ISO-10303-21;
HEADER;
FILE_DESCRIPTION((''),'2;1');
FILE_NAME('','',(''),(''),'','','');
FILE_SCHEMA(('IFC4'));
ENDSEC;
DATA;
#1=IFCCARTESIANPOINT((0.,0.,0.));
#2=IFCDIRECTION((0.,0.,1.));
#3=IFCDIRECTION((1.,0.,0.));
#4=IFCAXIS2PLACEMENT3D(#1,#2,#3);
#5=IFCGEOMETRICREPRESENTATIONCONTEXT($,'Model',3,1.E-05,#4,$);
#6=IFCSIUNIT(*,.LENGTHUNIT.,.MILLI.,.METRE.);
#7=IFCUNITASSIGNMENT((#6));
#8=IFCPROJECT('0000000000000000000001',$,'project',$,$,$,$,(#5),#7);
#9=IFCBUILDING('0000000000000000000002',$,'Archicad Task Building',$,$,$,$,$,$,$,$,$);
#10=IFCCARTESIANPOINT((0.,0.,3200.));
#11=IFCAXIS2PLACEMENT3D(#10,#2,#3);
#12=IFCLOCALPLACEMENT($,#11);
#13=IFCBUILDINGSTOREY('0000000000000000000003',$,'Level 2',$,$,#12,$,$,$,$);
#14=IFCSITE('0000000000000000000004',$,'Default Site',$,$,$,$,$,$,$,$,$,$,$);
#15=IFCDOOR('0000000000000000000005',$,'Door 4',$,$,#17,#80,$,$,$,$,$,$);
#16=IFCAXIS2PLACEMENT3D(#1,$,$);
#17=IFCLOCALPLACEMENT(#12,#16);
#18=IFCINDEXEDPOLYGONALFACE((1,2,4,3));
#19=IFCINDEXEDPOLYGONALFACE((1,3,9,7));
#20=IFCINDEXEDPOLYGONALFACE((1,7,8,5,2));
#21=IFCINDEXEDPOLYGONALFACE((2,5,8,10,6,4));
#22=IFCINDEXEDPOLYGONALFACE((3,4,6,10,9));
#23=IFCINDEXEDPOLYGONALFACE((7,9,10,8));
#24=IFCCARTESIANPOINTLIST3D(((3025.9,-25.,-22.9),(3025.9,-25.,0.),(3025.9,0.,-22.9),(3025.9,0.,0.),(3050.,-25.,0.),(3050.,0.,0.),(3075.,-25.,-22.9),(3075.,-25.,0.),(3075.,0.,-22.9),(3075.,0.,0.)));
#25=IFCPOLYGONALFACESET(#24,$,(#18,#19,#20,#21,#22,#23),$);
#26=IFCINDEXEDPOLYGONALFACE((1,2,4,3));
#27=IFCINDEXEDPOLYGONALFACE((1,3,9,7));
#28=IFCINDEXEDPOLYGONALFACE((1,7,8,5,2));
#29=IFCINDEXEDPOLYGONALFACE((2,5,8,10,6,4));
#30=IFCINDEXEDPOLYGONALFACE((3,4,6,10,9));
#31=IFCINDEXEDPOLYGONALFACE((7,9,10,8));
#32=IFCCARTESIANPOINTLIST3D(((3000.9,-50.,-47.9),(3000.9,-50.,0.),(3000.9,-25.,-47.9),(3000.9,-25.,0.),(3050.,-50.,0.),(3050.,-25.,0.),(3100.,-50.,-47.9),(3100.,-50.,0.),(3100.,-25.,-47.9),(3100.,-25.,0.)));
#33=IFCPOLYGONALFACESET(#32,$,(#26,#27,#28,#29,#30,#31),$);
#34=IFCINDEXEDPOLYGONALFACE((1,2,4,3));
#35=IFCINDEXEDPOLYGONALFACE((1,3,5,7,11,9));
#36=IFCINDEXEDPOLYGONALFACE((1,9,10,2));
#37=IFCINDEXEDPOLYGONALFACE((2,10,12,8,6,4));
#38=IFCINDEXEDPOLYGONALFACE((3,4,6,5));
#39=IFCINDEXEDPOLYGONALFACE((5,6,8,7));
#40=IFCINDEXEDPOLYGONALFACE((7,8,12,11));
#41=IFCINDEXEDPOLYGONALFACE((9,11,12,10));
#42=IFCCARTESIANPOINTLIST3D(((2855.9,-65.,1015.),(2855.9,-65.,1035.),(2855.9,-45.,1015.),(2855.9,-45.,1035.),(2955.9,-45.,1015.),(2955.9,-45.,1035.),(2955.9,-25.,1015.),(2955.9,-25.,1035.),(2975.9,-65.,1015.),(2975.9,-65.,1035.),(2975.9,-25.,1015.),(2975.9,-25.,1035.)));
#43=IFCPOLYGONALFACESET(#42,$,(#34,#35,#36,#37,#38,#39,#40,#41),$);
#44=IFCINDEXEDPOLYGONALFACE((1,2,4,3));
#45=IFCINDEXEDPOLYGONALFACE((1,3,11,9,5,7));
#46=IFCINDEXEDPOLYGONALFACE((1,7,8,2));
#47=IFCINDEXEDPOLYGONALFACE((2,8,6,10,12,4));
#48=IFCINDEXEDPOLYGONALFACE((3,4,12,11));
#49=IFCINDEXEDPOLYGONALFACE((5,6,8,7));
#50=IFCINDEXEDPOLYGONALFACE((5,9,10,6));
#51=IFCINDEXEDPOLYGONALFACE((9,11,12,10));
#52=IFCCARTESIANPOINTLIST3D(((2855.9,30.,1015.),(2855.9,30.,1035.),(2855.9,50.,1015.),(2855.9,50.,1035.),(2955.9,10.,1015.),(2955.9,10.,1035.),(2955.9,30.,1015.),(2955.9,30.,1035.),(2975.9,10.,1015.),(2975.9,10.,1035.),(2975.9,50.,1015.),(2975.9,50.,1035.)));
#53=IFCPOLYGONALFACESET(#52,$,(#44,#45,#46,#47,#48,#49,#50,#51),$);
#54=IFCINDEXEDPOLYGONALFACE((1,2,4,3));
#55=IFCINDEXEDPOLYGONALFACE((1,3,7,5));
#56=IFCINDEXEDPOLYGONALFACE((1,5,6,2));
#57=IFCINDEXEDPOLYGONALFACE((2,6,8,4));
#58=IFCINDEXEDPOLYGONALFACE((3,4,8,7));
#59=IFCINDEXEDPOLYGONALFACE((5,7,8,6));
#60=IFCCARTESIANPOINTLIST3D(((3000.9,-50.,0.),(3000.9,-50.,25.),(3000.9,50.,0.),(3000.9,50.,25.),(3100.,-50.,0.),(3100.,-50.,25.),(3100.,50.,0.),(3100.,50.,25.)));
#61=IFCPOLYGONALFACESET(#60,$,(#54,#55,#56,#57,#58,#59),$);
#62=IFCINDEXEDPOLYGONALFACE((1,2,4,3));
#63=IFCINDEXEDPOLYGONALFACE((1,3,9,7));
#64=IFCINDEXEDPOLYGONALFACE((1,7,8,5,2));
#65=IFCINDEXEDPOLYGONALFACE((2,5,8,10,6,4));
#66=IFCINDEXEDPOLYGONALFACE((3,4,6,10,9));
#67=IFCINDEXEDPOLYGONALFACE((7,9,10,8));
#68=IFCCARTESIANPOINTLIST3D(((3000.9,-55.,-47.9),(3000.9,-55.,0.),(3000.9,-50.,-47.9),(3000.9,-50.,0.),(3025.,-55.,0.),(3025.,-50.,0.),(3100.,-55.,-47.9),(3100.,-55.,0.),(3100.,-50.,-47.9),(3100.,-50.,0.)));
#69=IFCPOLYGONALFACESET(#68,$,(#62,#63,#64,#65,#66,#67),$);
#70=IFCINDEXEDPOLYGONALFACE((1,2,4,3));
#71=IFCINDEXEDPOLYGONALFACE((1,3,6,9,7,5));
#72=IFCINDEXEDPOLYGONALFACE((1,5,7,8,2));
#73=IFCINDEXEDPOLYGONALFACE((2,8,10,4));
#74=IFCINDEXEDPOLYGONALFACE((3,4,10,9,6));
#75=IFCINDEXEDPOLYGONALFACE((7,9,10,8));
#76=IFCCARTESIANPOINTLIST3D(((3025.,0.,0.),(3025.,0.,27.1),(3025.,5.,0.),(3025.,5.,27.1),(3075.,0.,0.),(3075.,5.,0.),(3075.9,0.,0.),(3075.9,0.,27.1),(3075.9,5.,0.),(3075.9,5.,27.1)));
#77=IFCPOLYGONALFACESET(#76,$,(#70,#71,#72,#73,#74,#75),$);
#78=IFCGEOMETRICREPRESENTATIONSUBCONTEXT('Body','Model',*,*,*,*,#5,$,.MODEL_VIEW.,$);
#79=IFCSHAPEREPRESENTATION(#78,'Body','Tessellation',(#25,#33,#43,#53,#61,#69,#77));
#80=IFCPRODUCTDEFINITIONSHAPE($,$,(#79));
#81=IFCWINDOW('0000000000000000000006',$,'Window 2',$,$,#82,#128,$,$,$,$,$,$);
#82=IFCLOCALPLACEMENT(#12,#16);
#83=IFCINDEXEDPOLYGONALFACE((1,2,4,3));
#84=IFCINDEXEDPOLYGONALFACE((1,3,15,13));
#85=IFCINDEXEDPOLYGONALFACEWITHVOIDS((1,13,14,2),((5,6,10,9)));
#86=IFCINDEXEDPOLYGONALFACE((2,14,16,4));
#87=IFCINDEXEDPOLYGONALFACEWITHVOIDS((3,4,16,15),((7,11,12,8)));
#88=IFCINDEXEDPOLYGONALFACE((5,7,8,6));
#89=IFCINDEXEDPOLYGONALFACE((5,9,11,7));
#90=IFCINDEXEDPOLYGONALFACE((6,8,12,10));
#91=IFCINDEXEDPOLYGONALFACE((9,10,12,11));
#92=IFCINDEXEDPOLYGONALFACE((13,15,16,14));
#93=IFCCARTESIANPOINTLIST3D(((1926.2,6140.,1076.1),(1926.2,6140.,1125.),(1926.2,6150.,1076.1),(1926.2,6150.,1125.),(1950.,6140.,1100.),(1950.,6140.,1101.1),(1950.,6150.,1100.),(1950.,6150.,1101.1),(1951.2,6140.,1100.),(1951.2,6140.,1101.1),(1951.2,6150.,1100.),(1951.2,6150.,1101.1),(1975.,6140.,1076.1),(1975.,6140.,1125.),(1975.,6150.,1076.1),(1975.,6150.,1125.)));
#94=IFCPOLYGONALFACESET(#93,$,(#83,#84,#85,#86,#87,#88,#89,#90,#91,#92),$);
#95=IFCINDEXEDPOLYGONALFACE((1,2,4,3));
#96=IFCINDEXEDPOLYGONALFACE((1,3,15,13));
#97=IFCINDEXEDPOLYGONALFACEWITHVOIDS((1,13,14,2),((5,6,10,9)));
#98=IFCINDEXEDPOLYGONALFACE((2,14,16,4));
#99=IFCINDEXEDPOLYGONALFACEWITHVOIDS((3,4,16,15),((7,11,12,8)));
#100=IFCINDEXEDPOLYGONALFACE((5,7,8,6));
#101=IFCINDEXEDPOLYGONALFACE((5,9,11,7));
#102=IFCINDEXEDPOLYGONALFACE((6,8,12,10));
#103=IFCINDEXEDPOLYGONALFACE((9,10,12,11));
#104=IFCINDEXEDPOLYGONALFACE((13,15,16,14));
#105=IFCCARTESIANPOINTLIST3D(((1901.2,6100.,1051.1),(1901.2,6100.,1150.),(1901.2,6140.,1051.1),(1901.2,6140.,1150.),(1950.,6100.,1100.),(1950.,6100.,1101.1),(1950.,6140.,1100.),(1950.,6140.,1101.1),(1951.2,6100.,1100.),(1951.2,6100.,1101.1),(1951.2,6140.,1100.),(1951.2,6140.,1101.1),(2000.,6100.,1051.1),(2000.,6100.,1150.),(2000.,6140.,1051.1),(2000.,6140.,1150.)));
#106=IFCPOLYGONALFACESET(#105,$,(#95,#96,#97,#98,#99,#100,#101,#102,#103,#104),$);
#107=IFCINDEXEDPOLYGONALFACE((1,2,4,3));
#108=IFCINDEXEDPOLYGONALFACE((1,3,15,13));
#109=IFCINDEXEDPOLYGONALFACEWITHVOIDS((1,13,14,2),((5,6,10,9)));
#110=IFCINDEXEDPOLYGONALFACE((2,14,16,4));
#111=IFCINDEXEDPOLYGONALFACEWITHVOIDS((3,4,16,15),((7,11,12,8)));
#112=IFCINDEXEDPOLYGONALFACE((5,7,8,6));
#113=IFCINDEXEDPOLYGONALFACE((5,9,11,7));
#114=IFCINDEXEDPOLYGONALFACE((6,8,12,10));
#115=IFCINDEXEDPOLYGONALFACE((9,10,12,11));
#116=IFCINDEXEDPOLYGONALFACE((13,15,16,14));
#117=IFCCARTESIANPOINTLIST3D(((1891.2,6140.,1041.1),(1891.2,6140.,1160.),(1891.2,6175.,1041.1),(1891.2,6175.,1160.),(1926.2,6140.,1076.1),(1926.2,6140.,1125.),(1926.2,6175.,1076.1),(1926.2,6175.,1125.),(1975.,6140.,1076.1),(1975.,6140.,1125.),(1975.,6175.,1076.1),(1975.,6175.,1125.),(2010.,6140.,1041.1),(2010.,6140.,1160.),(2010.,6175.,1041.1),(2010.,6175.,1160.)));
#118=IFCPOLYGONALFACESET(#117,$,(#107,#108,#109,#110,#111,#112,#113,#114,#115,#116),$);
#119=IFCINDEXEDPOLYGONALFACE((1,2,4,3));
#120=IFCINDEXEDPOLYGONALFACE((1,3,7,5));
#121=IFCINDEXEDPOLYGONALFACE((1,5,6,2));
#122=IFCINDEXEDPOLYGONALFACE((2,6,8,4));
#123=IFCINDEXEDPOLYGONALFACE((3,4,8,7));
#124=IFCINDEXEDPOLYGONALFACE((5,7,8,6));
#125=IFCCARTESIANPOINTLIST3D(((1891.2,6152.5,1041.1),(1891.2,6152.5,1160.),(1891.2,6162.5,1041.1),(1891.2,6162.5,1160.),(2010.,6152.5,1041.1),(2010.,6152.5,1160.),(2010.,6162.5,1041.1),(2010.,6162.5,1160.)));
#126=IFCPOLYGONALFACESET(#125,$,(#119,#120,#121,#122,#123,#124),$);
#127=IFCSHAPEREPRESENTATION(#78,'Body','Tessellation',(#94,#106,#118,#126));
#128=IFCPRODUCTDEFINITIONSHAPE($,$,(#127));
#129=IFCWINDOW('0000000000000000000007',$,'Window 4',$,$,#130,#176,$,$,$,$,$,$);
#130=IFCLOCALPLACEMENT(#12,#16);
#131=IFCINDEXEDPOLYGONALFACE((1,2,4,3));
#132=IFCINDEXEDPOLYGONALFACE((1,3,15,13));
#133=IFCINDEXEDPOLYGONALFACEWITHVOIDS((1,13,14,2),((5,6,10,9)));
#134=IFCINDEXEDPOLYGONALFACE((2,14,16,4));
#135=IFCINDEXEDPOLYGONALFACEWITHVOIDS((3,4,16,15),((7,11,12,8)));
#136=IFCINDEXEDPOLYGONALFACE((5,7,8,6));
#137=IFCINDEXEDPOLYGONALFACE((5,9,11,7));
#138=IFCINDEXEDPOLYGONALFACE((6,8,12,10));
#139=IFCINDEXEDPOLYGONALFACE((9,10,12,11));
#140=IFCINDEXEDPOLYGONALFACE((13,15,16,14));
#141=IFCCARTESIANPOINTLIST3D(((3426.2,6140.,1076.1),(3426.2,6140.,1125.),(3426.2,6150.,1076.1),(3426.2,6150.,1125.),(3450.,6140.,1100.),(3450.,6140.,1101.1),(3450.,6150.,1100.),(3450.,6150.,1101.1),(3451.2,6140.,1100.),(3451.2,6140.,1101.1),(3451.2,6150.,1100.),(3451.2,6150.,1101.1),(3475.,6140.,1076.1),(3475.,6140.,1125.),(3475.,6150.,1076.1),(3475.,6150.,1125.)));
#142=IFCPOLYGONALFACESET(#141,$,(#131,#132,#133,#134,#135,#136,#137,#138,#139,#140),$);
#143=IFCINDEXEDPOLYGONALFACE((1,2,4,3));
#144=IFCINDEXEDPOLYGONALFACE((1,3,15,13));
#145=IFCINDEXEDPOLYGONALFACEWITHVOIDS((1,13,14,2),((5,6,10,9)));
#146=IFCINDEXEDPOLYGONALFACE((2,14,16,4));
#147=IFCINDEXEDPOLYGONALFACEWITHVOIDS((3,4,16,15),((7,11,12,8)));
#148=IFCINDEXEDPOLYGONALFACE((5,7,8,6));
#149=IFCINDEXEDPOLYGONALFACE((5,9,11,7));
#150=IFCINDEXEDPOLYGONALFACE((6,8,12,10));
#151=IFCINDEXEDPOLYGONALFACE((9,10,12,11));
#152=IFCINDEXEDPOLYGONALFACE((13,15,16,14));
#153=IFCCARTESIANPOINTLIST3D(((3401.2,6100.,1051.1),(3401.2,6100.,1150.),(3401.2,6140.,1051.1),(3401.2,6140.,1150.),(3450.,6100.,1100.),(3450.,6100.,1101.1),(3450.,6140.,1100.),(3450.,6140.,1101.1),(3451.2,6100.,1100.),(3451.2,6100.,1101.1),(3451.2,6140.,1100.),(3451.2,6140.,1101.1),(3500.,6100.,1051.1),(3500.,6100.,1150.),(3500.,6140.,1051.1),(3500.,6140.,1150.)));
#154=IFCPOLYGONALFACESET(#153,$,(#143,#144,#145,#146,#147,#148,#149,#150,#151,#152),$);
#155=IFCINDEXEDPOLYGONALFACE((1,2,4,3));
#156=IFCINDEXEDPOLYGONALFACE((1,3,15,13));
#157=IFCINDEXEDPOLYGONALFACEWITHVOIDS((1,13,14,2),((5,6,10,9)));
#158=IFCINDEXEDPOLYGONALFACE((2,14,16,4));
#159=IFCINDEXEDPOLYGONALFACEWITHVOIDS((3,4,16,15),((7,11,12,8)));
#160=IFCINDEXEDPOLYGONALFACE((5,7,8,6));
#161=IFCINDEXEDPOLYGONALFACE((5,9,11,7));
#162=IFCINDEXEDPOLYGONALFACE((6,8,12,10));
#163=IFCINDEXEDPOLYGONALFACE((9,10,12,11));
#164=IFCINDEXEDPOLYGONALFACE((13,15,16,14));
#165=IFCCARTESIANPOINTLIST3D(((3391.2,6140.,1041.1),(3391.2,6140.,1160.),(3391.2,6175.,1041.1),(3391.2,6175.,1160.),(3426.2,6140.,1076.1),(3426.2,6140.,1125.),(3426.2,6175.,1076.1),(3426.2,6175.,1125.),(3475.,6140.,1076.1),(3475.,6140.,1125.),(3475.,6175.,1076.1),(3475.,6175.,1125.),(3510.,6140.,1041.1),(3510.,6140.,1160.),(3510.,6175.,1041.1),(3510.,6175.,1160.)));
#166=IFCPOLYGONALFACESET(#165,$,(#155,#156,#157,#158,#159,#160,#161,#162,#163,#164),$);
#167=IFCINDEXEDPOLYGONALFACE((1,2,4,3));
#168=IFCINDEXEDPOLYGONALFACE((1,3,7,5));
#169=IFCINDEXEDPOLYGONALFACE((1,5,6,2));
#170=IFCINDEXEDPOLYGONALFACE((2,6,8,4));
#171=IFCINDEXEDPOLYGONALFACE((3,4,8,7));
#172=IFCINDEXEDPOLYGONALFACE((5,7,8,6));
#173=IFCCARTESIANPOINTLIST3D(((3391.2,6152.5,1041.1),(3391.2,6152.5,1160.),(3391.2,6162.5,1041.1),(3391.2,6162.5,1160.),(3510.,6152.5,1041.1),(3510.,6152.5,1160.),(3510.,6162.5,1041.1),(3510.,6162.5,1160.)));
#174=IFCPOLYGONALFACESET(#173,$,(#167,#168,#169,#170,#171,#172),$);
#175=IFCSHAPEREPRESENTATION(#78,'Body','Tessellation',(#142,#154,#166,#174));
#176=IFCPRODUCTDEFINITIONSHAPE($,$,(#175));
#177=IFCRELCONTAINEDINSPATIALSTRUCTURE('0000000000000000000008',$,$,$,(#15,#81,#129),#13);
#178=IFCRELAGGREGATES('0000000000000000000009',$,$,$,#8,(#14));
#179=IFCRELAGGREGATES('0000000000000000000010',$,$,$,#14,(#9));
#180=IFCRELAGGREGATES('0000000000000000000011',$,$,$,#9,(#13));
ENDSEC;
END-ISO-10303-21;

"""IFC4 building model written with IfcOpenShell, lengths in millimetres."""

from ifc_helpers import new_model, si_unit, frame, origin_with_axes, place, context, subcontext, project, spatial, line, indexed_curve, outline, extrude, element, save


model = new_model("IFC4")

# Units and contexts
model_context = context("Model", 3, precision=1e-05, world=origin_with_axes())
body_context = subcontext(model_context, "Body", "Model", "MODEL_VIEW")
ifc_project = project(units=[si_unit("LENGTHUNIT", "METRE", prefix="MILLI")], contexts=[model_context])

# Site, building, storey
site = spatial("IfcSite", under=ifc_project, Name="Default Site")
building = spatial("IfcBuilding", under=site, Name="Archicad Task Building")
storey_placement = place(None, frame((0.0, 0.0, 3200.0), z_axis=(0.0, 0.0, 1.0), x_axis=(1.0, 0.0, 0.0)))
storey = spatial("IfcBuildingStorey", under=building, at=storey_placement, Name="Level 2")

# Door
door_1_placement = place(storey_placement, frame((3050.0, -50.0, 0.0), z_axis=(0.0, 0.0, 1.0), x_axis=(1.0, 0.0, 0.0)))
element("IfcDoor", 1, at=door_1_placement, inside=storey, Name="Door 4", context=body_context, shape_type="SweptSolid", body=[
    extrude(outline(indexed_curve([(0.0, 0.0), (0.0, 2.1), (0.9, 2.1), (0.9, 0.0), (-24.1, 0.0), (-24.1, -22.9), (25.0, -22.9), (25.0, 0.0)], segments=[line(1, 2, 3, 4, 5, 6, 7, 8, 1)])), frame((0.0, 25.0, 0.0), z_axis=(0.0, -1.0, 0.0), x_axis=(1.0, 0.0, 0.0)), (0.0, 0.0, -1.0), 25.0),
    extrude(outline(indexed_curve([(0.0, 0.0), (0.0, 2.1), (0.9, 2.1), (0.9, 0.0), (-49.1, 0.0), (-49.1, -47.9), (50.0, -47.9), (50.0, 0.0)], segments=[line(1, 2, 3, 4, 5, 6, 7, 8, 1)])), frame((0.0, 0.0, 0.0), z_axis=(0.0, -1.0, 0.0), x_axis=(1.0, 0.0, 0.0)), (0.0, 0.0, -1.0), 25.0),
    extrude(outline(indexed_curve([(0.0, 0.0), (-49.1, 0.0), (-49.1, 35.0), (0.0, 35.0)], segments=[line(1, 2, 3, 4, 1)])), frame((25.0, 25.0, 25.0), z_axis=(0.0, 0.0, 1.0), x_axis=(1.0, 0.0, 0.0)), (0.0, 0.0, 1.0), -47.9),
    extrude(outline(indexed_curve([(0.0, 0.0), (0.0, -40.0), (-120.0, -40.0), (-120.0, -20.0), (-20.0, -20.0), (-20.0, 0.0)], segments=[line(1, 2, 3, 4, 5, 6, 1)])), frame((-74.1, 25.0, 1015.0), z_axis=(0.0, 0.0, 1.0), x_axis=(1.0, 0.0, 0.0)), (0.0, 0.0, 1.0), 20.0),
    extrude(outline(indexed_curve([(0.0, 0.0), (0.0, 40.0), (-120.0, 40.0), (-120.0, 20.0), (-20.0, 20.0), (-20.0, 0.0)], segments=[line(1, 2, 3, 4, 5, 6, 1)])), frame((-74.1, 60.0, 1015.0), z_axis=(0.0, 0.0, 1.0), x_axis=(1.0, 0.0, 0.0)), (0.0, 0.0, 1.0), 20.0),
    extrude(outline(indexed_curve([(0.0, 0.0), (-99.1, 0.0), (-99.1, 100.0), (0.0, 100.0)], segments=[line(1, 2, 3, 4, 1)])), frame((50.0, 0.0, 0.0), z_axis=(0.0, 0.0, 1.0), x_axis=(1.0, 0.0, 0.0)), (0.0, 0.0, 1.0), 25.0),
    extrude(outline(indexed_curve([(0.0, 0.0), (0.0, 27.1), (50.9, 27.1), (50.9, 0.0), (-24.1, 0.0), (-24.1, -47.9), (75.0, -47.9), (75.0, 0.0)], segments=[line(1, 2, 3, 4, 5, 6, 7, 8, 1)])), frame((-25.0, -5.0, 0.0), z_axis=(0.0, -1.0, 0.0), x_axis=(1.0, 0.0, 0.0)), (0.0, 0.0, -1.0), 5.0),
    extrude(outline(indexed_curve([(0.0, 0.0), (0.0, 27.1), (50.9, 27.1), (50.9, 0.0), (0.9, 0.0), (0.9, -22.9), (50.0, -22.9), (50.0, 0.0)], segments=[line(1, 2, 3, 4, 5, 6, 7, 8, 1)])), frame((-25.0, 50.0, 0.0), z_axis=(0.0, -1.0, 0.0), x_axis=(1.0, 0.0, 0.0)), (0.0, 0.0, -1.0), 5.0),
])

# Windows
for number, where, z_axis, x_axis, name in (
    (2, (1950.0, 6050.0, 1100.0), (0.0, 0.0, 1.0), (1.0, 0.0, 0.0), "Window 2"),
    (3, (3450.0, 6050.0, 1100.0), (0.0, 0.0, 1.0), (1.0, 0.0, 0.0), "Window 4"),
):
    element("IfcWindow", number, at=place(storey_placement, frame(where, z_axis=z_axis, x_axis=x_axis)), inside=storey, Name=name, context=body_context, shape_type="SweptSolid", body=[
        extrude(outline(indexed_curve([(0.0, 0.0), (1.2, 0.0), (1.2, 1.1), (0.0, 1.1)], segments=[line(1, 2, 3, 4, 1)]), holes=[indexed_curve([(25.0, 25.0), (-23.8, 25.0), (-23.8, -23.9), (25.0, -23.9)], segments=[line(1, 2, 3, 4, 1)])]), frame((0.0, 90.0, 0.0), z_axis=(0.0, -1.0, 0.0), x_axis=(1.0, 0.0, 0.0)), (0.0, 0.0, -1.0), 10.0),
        extrude(outline(indexed_curve([(0.0, 0.0), (1.2, 0.0), (1.2, 1.1), (0.0, 1.1)], segments=[line(1, 2, 3, 4, 1)]), holes=[indexed_curve([(50.0, 50.0), (-48.8, 50.0), (-48.8, -48.9), (50.0, -48.9)], segments=[line(1, 2, 3, 4, 1)])]), frame((0.0, 50.0, 0.0), z_axis=(0.0, -1.0, 0.0), x_axis=(1.0, 0.0, 0.0)), (0.0, 0.0, -1.0), 40.0),
        extrude(outline(indexed_curve([(0.0, 0.0), (-48.8, 0.0), (-48.8, -48.9), (0.0, -48.9)], segments=[line(1, 2, 3, 4, 1)]), holes=[indexed_curve([(35.0, 35.0), (-83.8, 35.0), (-83.8, -83.9), (35.0, -83.9)], segments=[line(1, 2, 3, 4, 1)])]), frame((25.0, 90.0, 25.0), z_axis=(0.0, -1.0, 0.0), x_axis=(1.0, 0.0, 0.0)), (0.0, 0.0, -1.0), 35.0),
        extrude(outline(indexed_curve([(35.0, 35.0), (-83.8, 35.0), (-83.8, -83.9), (35.0, -83.9)], segments=[line(1, 2, 3, 4, 1)])), frame((25.0, 102.5, 25.0), z_axis=(0.0, -1.0, 0.0), x_axis=(1.0, 0.0, 0.0)), (0.0, 0.0, -1.0), 10.0),
    ])

save(model, "model.ifc")
